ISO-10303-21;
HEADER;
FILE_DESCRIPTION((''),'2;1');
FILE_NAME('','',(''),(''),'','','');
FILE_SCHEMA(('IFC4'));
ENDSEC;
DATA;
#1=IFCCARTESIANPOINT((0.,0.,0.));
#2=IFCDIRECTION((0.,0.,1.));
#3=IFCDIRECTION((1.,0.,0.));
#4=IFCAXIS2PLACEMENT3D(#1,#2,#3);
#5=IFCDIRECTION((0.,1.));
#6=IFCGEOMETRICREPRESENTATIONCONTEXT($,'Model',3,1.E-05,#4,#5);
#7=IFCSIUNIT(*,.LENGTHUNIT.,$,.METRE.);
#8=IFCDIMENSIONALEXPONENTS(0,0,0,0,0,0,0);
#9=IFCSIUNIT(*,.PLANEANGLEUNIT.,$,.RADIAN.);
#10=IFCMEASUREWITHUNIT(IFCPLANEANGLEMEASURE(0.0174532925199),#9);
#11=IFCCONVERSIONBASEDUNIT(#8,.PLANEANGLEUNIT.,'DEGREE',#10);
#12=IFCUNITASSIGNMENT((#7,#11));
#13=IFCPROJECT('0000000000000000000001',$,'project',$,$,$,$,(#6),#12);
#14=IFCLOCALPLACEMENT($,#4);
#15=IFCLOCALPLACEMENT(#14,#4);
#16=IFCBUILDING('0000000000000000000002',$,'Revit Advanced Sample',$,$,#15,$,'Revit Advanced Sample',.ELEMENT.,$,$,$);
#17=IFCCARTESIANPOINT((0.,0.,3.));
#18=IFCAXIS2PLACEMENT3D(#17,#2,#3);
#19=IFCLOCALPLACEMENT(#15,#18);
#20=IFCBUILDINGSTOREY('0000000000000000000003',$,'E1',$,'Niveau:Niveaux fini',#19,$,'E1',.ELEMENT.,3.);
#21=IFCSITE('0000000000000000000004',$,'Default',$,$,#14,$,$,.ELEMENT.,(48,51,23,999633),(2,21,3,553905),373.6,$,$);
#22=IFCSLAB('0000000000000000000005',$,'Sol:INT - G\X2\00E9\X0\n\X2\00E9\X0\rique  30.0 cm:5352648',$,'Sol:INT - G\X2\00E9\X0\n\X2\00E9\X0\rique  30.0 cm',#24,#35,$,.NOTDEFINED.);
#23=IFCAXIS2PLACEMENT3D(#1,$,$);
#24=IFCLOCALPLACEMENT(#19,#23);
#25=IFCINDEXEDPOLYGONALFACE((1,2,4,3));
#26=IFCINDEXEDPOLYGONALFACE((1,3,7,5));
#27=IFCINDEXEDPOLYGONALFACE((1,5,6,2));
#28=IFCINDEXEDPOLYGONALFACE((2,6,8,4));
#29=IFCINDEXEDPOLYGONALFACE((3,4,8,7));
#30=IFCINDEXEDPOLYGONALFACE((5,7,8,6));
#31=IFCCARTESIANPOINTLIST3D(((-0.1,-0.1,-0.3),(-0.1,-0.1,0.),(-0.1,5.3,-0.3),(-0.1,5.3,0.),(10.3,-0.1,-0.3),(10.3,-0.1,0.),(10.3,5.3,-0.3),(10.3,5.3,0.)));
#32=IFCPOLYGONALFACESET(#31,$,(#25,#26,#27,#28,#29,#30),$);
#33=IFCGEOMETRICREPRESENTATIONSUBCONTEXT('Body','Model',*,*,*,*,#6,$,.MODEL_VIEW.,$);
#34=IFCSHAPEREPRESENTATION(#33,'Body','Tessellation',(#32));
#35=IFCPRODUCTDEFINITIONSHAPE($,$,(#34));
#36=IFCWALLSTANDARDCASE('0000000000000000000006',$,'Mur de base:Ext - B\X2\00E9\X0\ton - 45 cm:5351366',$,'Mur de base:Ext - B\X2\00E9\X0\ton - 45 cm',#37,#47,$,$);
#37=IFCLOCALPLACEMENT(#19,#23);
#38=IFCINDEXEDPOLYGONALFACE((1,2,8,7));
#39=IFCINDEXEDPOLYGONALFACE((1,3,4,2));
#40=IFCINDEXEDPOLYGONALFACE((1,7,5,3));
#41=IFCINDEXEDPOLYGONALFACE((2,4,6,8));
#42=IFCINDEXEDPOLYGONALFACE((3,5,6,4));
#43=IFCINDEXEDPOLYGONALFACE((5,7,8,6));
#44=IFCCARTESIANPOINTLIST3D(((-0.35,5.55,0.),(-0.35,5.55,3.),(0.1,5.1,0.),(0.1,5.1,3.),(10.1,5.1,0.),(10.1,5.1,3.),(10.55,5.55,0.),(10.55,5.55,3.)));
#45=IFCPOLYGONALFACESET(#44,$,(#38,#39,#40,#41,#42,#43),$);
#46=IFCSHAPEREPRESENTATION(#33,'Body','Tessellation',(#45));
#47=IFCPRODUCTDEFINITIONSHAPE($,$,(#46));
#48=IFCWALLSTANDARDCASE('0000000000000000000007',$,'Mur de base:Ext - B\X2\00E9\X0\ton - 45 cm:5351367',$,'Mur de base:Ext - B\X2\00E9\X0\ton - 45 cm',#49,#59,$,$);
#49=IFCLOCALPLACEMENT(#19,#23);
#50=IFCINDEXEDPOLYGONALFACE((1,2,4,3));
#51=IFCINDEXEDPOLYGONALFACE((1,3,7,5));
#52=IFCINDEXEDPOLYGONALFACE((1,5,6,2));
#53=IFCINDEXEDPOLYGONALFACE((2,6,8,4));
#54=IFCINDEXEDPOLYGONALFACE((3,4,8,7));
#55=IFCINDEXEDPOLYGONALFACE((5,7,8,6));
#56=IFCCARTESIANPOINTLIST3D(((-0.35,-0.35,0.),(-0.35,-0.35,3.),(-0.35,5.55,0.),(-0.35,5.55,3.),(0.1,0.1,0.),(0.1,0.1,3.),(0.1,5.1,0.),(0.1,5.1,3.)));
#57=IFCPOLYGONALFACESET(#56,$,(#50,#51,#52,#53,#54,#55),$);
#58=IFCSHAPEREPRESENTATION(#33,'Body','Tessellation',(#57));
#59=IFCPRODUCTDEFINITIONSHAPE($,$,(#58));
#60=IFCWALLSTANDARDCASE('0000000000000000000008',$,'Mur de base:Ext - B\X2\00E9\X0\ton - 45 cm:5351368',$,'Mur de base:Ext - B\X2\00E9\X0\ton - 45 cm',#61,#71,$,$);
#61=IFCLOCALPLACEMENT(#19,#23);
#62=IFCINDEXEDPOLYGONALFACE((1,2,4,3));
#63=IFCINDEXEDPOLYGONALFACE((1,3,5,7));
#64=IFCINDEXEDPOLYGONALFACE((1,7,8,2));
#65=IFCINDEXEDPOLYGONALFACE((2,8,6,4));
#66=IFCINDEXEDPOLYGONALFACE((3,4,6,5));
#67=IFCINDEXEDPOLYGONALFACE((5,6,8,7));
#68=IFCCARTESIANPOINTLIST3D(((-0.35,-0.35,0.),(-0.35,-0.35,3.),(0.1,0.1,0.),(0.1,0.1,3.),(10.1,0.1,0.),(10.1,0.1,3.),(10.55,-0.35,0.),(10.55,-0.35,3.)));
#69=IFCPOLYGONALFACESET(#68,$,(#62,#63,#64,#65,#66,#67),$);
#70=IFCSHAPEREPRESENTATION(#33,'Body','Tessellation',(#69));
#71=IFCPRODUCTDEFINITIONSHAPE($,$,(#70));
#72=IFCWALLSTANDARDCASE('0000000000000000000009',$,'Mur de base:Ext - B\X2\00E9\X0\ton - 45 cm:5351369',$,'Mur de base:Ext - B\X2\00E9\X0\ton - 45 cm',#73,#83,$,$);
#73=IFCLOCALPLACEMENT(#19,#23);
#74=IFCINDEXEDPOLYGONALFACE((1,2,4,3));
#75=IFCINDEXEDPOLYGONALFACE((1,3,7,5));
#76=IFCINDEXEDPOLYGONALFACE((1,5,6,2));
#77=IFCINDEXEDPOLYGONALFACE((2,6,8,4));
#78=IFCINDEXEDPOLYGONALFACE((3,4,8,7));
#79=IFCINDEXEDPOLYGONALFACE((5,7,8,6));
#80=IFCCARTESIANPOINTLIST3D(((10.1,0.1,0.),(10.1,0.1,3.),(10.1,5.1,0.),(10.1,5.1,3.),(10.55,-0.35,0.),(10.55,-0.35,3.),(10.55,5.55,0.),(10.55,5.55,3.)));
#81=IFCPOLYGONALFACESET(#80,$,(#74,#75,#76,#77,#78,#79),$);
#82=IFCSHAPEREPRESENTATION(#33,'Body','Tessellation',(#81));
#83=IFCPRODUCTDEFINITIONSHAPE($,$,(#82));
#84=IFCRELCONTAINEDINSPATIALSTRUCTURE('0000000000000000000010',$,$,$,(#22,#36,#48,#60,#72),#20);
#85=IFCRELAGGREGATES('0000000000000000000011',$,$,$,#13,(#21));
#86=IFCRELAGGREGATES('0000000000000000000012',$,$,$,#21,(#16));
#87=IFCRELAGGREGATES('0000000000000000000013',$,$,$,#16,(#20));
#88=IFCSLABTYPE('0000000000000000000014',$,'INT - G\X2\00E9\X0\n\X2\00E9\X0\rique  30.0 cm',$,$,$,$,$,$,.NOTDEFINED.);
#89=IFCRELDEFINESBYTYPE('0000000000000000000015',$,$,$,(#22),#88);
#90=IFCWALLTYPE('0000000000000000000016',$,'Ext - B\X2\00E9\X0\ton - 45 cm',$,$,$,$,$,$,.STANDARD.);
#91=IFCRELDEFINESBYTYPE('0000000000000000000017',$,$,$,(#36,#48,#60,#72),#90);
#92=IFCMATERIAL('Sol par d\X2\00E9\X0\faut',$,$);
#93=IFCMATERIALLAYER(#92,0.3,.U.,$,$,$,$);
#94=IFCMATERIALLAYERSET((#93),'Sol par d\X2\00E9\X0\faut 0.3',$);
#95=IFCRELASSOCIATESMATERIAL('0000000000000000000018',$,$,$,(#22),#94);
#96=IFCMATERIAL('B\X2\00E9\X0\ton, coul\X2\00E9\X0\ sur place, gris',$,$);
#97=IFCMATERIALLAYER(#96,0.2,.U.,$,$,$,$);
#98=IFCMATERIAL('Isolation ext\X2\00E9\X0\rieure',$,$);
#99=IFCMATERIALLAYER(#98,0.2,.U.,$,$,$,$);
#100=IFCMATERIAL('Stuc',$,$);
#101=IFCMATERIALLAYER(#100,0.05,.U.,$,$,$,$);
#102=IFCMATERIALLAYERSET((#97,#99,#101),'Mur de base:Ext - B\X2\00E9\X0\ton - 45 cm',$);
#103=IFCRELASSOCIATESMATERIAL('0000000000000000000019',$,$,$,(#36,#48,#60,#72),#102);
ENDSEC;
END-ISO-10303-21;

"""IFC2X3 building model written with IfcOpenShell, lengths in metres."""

from ifc_helpers import new_model, entity, si_unit, converted_unit, direction, frame, origin_with_axes, place, context, subcontext, project, spatial, polyline, outline, extrude, material, layer, layer_set, layer_usage, type_object, element, save


model = new_model("IFC2X3")

# Units and contexts
model_context = context("Model", 3, precision=1e-05, world=origin_with_axes(), true_north=direction((0.0, 1.0)))
body_context = subcontext(model_context, "Body", "Model", "MODEL_VIEW")
ifc_project = project(units=[si_unit("LENGTHUNIT", "METRE"), converted_unit("PLANEANGLEUNIT", "DEGREE", entity("IfcPlaneAngleMeasure", 0.0174532925199), si_unit("PLANEANGLEUNIT", "RADIAN"), dimensions=[0, 0, 0, 0, 0, 0, 0])], contexts=[model_context])

# Site, building, storey
site_placement = place(None, origin_with_axes())
site = spatial("IfcSite", under=ifc_project, at=site_placement, Name="Default", CompositionType="ELEMENT", RefLatitude=(48, 51, 23, 999633), RefLongitude=(2, 21, 3, 553905), RefElevation=373.6)
building_placement = place(site_placement, origin_with_axes())
building = spatial("IfcBuilding", under=site, at=building_placement, Name="Revit Advanced Sample", LongName="Revit Advanced Sample", CompositionType="ELEMENT")
storey_placement = place(building_placement, frame((0.0, 0.0, 3.0), z_axis=(0.0, 0.0, 1.0), x_axis=(1.0, 0.0, 0.0)))
storey = spatial("IfcBuildingStorey", under=building, at=storey_placement, Name="E1", ObjectType="Niveau:Niveaux fini", LongName="E1", CompositionType="ELEMENT", Elevation=3.0)

# Slab
ifc_material_1 = material(Name="Sol par défaut")
ifc_layer_1 = layer(ifc_material_1, 0.3, ventilated="UNKNOWN")
ifc_layer_set_1 = layer_set([ifc_layer_1], Name="Sol par défaut 0.3")
ifc_layer_usage_1 = layer_usage(ifc_layer_set_1, "AXIS3", "NEGATIVE", 0.3)
slab_type = type_object("IfcSlabType", Name="INT - Générique  30.0 cm", PredefinedType="NOTDEFINED")
slab_placement = place(storey_placement, frame((-0.1, 5.3, 0.0), z_axis=(0.0, 0.0, 1.0), x_axis=(1.0, 0.0, 0.0)))
element("IfcSlab", 1, at=slab_placement, inside=storey, type_object=slab_type, material=ifc_layer_usage_1, Name="Sol:INT - Générique  30.0 cm:5352648", ObjectType="Sol:INT - Générique  30.0 cm", PredefinedType="NOTDEFINED", context=body_context, shape_type="SweptSolid", body=[
    extrude(outline(polyline([(0.0, 0.0), (0.0, -5.4), (10.4, -5.4), (10.4, 0.0), (0.0, 0.0)])), frame((0.0, 0.0, -0.3), z_axis=(0.0, 0.0, 1.0), x_axis=(1.0, 0.0, 0.0)), (0.0, 0.0, 1.0), 0.3),
])

# Walls
ifc_material_2 = material(Name="Béton, coulé sur place, gris")
ifc_layer_2 = layer(ifc_material_2, 0.2, ventilated="UNKNOWN")
ifc_material_3 = material(Name="Isolation extérieure")
ifc_layer_3 = layer(ifc_material_3, 0.2, ventilated="UNKNOWN")
ifc_material_4 = material(Name="Stuc")
ifc_layer_4 = layer(ifc_material_4, 0.05, ventilated="UNKNOWN")
ifc_layer_set_2 = layer_set([ifc_layer_2, ifc_layer_3, ifc_layer_4], Name="Mur de base:Ext - Béton - 45 cm")
ifc_layer_usage_2 = layer_usage(ifc_layer_set_2, "AXIS2", "POSITIVE", -0.225)
wall_type_1 = type_object("IfcWallType", Name="Ext - Béton - 45 cm", PredefinedType="STANDARD")
wall_1_placement = place(storey_placement, frame((-0.125, 5.325, 0.0), z_axis=(0.0, 0.0, 1.0), x_axis=(1.0, 0.0, 0.0)))
element("IfcWallStandardCase", 2, at=wall_1_placement, inside=storey, type_object=wall_type_1, material=ifc_layer_usage_2, Name="Mur de base:Ext - Béton - 45 cm:5351366", ObjectType="Mur de base:Ext - Béton - 45 cm", context=body_context, shape_type="SweptSolid", body=[
    extrude(outline(polyline([(0.225, -0.225), (10.225, -0.225), (10.675, 0.225), (-0.225, 0.225), (0.225, -0.225)])), origin_with_axes(), (0.0, 0.0, 1.0), 3.0),
])
ifc_layer_usage_3 = layer_usage(ifc_layer_set_2, "AXIS2", "POSITIVE", -0.225)
wall_2_placement = place(storey_placement, frame((-0.125, -0.125, 0.0), z_axis=(0.0, 0.0, 1.0), x_axis=(0.0, 1.0, 0.0)))
element("IfcWallStandardCase", 3, at=wall_2_placement, inside=storey, type_object=wall_type_1, material=ifc_layer_usage_3, Name="Mur de base:Ext - Béton - 45 cm:5351367", ObjectType="Mur de base:Ext - Béton - 45 cm", context=body_context, shape_type="SweptSolid", body=[
    extrude(outline(polyline([(0.225, -0.225), (5.225, -0.225), (5.675, 0.225), (-0.225, 0.225), (0.225, -0.225)])), origin_with_axes(), (0.0, 0.0, 1.0), 3.0),
])
ifc_layer_usage_4 = layer_usage(ifc_layer_set_2, "AXIS2", "POSITIVE", -0.225)
wall_3_placement = place(storey_placement, frame((10.325, -0.125, 0.0), z_axis=(0.0, 0.0, 1.0), x_axis=(-1.0, 0.0, 0.0)))
element("IfcWallStandardCase", 4, at=wall_3_placement, inside=storey, type_object=wall_type_1, material=ifc_layer_usage_4, Name="Mur de base:Ext - Béton - 45 cm:5351368", ObjectType="Mur de base:Ext - Béton - 45 cm", context=body_context, shape_type="SweptSolid", body=[
    extrude(outline(polyline([(0.225, -0.225), (10.225, -0.225), (10.675, 0.225), (-0.225, 0.225), (0.225, -0.225)])), origin_with_axes(), (0.0, 0.0, 1.0), 3.0),
])
ifc_layer_usage_5 = layer_usage(ifc_layer_set_2, "AXIS2", "POSITIVE", -0.225)
wall_4_placement = place(storey_placement, frame((10.325, 5.325, 0.0), z_axis=(0.0, 0.0, 1.0), x_axis=(0.0, -1.0, 0.0)))
element("IfcWallStandardCase", 5, at=wall_4_placement, inside=storey, type_object=wall_type_1, material=ifc_layer_usage_5, Name="Mur de base:Ext - Béton - 45 cm:5351369", ObjectType="Mur de base:Ext - Béton - 45 cm", context=body_context, shape_type="SweptSolid", body=[
    extrude(outline(polyline([(0.225, -0.225), (5.225, -0.225), (5.675, 0.225), (-0.225, 0.225), (0.225, -0.225)])), origin_with_axes(), (0.0, 0.0, 1.0), 3.0),
])

save(model, "model.ifc")
